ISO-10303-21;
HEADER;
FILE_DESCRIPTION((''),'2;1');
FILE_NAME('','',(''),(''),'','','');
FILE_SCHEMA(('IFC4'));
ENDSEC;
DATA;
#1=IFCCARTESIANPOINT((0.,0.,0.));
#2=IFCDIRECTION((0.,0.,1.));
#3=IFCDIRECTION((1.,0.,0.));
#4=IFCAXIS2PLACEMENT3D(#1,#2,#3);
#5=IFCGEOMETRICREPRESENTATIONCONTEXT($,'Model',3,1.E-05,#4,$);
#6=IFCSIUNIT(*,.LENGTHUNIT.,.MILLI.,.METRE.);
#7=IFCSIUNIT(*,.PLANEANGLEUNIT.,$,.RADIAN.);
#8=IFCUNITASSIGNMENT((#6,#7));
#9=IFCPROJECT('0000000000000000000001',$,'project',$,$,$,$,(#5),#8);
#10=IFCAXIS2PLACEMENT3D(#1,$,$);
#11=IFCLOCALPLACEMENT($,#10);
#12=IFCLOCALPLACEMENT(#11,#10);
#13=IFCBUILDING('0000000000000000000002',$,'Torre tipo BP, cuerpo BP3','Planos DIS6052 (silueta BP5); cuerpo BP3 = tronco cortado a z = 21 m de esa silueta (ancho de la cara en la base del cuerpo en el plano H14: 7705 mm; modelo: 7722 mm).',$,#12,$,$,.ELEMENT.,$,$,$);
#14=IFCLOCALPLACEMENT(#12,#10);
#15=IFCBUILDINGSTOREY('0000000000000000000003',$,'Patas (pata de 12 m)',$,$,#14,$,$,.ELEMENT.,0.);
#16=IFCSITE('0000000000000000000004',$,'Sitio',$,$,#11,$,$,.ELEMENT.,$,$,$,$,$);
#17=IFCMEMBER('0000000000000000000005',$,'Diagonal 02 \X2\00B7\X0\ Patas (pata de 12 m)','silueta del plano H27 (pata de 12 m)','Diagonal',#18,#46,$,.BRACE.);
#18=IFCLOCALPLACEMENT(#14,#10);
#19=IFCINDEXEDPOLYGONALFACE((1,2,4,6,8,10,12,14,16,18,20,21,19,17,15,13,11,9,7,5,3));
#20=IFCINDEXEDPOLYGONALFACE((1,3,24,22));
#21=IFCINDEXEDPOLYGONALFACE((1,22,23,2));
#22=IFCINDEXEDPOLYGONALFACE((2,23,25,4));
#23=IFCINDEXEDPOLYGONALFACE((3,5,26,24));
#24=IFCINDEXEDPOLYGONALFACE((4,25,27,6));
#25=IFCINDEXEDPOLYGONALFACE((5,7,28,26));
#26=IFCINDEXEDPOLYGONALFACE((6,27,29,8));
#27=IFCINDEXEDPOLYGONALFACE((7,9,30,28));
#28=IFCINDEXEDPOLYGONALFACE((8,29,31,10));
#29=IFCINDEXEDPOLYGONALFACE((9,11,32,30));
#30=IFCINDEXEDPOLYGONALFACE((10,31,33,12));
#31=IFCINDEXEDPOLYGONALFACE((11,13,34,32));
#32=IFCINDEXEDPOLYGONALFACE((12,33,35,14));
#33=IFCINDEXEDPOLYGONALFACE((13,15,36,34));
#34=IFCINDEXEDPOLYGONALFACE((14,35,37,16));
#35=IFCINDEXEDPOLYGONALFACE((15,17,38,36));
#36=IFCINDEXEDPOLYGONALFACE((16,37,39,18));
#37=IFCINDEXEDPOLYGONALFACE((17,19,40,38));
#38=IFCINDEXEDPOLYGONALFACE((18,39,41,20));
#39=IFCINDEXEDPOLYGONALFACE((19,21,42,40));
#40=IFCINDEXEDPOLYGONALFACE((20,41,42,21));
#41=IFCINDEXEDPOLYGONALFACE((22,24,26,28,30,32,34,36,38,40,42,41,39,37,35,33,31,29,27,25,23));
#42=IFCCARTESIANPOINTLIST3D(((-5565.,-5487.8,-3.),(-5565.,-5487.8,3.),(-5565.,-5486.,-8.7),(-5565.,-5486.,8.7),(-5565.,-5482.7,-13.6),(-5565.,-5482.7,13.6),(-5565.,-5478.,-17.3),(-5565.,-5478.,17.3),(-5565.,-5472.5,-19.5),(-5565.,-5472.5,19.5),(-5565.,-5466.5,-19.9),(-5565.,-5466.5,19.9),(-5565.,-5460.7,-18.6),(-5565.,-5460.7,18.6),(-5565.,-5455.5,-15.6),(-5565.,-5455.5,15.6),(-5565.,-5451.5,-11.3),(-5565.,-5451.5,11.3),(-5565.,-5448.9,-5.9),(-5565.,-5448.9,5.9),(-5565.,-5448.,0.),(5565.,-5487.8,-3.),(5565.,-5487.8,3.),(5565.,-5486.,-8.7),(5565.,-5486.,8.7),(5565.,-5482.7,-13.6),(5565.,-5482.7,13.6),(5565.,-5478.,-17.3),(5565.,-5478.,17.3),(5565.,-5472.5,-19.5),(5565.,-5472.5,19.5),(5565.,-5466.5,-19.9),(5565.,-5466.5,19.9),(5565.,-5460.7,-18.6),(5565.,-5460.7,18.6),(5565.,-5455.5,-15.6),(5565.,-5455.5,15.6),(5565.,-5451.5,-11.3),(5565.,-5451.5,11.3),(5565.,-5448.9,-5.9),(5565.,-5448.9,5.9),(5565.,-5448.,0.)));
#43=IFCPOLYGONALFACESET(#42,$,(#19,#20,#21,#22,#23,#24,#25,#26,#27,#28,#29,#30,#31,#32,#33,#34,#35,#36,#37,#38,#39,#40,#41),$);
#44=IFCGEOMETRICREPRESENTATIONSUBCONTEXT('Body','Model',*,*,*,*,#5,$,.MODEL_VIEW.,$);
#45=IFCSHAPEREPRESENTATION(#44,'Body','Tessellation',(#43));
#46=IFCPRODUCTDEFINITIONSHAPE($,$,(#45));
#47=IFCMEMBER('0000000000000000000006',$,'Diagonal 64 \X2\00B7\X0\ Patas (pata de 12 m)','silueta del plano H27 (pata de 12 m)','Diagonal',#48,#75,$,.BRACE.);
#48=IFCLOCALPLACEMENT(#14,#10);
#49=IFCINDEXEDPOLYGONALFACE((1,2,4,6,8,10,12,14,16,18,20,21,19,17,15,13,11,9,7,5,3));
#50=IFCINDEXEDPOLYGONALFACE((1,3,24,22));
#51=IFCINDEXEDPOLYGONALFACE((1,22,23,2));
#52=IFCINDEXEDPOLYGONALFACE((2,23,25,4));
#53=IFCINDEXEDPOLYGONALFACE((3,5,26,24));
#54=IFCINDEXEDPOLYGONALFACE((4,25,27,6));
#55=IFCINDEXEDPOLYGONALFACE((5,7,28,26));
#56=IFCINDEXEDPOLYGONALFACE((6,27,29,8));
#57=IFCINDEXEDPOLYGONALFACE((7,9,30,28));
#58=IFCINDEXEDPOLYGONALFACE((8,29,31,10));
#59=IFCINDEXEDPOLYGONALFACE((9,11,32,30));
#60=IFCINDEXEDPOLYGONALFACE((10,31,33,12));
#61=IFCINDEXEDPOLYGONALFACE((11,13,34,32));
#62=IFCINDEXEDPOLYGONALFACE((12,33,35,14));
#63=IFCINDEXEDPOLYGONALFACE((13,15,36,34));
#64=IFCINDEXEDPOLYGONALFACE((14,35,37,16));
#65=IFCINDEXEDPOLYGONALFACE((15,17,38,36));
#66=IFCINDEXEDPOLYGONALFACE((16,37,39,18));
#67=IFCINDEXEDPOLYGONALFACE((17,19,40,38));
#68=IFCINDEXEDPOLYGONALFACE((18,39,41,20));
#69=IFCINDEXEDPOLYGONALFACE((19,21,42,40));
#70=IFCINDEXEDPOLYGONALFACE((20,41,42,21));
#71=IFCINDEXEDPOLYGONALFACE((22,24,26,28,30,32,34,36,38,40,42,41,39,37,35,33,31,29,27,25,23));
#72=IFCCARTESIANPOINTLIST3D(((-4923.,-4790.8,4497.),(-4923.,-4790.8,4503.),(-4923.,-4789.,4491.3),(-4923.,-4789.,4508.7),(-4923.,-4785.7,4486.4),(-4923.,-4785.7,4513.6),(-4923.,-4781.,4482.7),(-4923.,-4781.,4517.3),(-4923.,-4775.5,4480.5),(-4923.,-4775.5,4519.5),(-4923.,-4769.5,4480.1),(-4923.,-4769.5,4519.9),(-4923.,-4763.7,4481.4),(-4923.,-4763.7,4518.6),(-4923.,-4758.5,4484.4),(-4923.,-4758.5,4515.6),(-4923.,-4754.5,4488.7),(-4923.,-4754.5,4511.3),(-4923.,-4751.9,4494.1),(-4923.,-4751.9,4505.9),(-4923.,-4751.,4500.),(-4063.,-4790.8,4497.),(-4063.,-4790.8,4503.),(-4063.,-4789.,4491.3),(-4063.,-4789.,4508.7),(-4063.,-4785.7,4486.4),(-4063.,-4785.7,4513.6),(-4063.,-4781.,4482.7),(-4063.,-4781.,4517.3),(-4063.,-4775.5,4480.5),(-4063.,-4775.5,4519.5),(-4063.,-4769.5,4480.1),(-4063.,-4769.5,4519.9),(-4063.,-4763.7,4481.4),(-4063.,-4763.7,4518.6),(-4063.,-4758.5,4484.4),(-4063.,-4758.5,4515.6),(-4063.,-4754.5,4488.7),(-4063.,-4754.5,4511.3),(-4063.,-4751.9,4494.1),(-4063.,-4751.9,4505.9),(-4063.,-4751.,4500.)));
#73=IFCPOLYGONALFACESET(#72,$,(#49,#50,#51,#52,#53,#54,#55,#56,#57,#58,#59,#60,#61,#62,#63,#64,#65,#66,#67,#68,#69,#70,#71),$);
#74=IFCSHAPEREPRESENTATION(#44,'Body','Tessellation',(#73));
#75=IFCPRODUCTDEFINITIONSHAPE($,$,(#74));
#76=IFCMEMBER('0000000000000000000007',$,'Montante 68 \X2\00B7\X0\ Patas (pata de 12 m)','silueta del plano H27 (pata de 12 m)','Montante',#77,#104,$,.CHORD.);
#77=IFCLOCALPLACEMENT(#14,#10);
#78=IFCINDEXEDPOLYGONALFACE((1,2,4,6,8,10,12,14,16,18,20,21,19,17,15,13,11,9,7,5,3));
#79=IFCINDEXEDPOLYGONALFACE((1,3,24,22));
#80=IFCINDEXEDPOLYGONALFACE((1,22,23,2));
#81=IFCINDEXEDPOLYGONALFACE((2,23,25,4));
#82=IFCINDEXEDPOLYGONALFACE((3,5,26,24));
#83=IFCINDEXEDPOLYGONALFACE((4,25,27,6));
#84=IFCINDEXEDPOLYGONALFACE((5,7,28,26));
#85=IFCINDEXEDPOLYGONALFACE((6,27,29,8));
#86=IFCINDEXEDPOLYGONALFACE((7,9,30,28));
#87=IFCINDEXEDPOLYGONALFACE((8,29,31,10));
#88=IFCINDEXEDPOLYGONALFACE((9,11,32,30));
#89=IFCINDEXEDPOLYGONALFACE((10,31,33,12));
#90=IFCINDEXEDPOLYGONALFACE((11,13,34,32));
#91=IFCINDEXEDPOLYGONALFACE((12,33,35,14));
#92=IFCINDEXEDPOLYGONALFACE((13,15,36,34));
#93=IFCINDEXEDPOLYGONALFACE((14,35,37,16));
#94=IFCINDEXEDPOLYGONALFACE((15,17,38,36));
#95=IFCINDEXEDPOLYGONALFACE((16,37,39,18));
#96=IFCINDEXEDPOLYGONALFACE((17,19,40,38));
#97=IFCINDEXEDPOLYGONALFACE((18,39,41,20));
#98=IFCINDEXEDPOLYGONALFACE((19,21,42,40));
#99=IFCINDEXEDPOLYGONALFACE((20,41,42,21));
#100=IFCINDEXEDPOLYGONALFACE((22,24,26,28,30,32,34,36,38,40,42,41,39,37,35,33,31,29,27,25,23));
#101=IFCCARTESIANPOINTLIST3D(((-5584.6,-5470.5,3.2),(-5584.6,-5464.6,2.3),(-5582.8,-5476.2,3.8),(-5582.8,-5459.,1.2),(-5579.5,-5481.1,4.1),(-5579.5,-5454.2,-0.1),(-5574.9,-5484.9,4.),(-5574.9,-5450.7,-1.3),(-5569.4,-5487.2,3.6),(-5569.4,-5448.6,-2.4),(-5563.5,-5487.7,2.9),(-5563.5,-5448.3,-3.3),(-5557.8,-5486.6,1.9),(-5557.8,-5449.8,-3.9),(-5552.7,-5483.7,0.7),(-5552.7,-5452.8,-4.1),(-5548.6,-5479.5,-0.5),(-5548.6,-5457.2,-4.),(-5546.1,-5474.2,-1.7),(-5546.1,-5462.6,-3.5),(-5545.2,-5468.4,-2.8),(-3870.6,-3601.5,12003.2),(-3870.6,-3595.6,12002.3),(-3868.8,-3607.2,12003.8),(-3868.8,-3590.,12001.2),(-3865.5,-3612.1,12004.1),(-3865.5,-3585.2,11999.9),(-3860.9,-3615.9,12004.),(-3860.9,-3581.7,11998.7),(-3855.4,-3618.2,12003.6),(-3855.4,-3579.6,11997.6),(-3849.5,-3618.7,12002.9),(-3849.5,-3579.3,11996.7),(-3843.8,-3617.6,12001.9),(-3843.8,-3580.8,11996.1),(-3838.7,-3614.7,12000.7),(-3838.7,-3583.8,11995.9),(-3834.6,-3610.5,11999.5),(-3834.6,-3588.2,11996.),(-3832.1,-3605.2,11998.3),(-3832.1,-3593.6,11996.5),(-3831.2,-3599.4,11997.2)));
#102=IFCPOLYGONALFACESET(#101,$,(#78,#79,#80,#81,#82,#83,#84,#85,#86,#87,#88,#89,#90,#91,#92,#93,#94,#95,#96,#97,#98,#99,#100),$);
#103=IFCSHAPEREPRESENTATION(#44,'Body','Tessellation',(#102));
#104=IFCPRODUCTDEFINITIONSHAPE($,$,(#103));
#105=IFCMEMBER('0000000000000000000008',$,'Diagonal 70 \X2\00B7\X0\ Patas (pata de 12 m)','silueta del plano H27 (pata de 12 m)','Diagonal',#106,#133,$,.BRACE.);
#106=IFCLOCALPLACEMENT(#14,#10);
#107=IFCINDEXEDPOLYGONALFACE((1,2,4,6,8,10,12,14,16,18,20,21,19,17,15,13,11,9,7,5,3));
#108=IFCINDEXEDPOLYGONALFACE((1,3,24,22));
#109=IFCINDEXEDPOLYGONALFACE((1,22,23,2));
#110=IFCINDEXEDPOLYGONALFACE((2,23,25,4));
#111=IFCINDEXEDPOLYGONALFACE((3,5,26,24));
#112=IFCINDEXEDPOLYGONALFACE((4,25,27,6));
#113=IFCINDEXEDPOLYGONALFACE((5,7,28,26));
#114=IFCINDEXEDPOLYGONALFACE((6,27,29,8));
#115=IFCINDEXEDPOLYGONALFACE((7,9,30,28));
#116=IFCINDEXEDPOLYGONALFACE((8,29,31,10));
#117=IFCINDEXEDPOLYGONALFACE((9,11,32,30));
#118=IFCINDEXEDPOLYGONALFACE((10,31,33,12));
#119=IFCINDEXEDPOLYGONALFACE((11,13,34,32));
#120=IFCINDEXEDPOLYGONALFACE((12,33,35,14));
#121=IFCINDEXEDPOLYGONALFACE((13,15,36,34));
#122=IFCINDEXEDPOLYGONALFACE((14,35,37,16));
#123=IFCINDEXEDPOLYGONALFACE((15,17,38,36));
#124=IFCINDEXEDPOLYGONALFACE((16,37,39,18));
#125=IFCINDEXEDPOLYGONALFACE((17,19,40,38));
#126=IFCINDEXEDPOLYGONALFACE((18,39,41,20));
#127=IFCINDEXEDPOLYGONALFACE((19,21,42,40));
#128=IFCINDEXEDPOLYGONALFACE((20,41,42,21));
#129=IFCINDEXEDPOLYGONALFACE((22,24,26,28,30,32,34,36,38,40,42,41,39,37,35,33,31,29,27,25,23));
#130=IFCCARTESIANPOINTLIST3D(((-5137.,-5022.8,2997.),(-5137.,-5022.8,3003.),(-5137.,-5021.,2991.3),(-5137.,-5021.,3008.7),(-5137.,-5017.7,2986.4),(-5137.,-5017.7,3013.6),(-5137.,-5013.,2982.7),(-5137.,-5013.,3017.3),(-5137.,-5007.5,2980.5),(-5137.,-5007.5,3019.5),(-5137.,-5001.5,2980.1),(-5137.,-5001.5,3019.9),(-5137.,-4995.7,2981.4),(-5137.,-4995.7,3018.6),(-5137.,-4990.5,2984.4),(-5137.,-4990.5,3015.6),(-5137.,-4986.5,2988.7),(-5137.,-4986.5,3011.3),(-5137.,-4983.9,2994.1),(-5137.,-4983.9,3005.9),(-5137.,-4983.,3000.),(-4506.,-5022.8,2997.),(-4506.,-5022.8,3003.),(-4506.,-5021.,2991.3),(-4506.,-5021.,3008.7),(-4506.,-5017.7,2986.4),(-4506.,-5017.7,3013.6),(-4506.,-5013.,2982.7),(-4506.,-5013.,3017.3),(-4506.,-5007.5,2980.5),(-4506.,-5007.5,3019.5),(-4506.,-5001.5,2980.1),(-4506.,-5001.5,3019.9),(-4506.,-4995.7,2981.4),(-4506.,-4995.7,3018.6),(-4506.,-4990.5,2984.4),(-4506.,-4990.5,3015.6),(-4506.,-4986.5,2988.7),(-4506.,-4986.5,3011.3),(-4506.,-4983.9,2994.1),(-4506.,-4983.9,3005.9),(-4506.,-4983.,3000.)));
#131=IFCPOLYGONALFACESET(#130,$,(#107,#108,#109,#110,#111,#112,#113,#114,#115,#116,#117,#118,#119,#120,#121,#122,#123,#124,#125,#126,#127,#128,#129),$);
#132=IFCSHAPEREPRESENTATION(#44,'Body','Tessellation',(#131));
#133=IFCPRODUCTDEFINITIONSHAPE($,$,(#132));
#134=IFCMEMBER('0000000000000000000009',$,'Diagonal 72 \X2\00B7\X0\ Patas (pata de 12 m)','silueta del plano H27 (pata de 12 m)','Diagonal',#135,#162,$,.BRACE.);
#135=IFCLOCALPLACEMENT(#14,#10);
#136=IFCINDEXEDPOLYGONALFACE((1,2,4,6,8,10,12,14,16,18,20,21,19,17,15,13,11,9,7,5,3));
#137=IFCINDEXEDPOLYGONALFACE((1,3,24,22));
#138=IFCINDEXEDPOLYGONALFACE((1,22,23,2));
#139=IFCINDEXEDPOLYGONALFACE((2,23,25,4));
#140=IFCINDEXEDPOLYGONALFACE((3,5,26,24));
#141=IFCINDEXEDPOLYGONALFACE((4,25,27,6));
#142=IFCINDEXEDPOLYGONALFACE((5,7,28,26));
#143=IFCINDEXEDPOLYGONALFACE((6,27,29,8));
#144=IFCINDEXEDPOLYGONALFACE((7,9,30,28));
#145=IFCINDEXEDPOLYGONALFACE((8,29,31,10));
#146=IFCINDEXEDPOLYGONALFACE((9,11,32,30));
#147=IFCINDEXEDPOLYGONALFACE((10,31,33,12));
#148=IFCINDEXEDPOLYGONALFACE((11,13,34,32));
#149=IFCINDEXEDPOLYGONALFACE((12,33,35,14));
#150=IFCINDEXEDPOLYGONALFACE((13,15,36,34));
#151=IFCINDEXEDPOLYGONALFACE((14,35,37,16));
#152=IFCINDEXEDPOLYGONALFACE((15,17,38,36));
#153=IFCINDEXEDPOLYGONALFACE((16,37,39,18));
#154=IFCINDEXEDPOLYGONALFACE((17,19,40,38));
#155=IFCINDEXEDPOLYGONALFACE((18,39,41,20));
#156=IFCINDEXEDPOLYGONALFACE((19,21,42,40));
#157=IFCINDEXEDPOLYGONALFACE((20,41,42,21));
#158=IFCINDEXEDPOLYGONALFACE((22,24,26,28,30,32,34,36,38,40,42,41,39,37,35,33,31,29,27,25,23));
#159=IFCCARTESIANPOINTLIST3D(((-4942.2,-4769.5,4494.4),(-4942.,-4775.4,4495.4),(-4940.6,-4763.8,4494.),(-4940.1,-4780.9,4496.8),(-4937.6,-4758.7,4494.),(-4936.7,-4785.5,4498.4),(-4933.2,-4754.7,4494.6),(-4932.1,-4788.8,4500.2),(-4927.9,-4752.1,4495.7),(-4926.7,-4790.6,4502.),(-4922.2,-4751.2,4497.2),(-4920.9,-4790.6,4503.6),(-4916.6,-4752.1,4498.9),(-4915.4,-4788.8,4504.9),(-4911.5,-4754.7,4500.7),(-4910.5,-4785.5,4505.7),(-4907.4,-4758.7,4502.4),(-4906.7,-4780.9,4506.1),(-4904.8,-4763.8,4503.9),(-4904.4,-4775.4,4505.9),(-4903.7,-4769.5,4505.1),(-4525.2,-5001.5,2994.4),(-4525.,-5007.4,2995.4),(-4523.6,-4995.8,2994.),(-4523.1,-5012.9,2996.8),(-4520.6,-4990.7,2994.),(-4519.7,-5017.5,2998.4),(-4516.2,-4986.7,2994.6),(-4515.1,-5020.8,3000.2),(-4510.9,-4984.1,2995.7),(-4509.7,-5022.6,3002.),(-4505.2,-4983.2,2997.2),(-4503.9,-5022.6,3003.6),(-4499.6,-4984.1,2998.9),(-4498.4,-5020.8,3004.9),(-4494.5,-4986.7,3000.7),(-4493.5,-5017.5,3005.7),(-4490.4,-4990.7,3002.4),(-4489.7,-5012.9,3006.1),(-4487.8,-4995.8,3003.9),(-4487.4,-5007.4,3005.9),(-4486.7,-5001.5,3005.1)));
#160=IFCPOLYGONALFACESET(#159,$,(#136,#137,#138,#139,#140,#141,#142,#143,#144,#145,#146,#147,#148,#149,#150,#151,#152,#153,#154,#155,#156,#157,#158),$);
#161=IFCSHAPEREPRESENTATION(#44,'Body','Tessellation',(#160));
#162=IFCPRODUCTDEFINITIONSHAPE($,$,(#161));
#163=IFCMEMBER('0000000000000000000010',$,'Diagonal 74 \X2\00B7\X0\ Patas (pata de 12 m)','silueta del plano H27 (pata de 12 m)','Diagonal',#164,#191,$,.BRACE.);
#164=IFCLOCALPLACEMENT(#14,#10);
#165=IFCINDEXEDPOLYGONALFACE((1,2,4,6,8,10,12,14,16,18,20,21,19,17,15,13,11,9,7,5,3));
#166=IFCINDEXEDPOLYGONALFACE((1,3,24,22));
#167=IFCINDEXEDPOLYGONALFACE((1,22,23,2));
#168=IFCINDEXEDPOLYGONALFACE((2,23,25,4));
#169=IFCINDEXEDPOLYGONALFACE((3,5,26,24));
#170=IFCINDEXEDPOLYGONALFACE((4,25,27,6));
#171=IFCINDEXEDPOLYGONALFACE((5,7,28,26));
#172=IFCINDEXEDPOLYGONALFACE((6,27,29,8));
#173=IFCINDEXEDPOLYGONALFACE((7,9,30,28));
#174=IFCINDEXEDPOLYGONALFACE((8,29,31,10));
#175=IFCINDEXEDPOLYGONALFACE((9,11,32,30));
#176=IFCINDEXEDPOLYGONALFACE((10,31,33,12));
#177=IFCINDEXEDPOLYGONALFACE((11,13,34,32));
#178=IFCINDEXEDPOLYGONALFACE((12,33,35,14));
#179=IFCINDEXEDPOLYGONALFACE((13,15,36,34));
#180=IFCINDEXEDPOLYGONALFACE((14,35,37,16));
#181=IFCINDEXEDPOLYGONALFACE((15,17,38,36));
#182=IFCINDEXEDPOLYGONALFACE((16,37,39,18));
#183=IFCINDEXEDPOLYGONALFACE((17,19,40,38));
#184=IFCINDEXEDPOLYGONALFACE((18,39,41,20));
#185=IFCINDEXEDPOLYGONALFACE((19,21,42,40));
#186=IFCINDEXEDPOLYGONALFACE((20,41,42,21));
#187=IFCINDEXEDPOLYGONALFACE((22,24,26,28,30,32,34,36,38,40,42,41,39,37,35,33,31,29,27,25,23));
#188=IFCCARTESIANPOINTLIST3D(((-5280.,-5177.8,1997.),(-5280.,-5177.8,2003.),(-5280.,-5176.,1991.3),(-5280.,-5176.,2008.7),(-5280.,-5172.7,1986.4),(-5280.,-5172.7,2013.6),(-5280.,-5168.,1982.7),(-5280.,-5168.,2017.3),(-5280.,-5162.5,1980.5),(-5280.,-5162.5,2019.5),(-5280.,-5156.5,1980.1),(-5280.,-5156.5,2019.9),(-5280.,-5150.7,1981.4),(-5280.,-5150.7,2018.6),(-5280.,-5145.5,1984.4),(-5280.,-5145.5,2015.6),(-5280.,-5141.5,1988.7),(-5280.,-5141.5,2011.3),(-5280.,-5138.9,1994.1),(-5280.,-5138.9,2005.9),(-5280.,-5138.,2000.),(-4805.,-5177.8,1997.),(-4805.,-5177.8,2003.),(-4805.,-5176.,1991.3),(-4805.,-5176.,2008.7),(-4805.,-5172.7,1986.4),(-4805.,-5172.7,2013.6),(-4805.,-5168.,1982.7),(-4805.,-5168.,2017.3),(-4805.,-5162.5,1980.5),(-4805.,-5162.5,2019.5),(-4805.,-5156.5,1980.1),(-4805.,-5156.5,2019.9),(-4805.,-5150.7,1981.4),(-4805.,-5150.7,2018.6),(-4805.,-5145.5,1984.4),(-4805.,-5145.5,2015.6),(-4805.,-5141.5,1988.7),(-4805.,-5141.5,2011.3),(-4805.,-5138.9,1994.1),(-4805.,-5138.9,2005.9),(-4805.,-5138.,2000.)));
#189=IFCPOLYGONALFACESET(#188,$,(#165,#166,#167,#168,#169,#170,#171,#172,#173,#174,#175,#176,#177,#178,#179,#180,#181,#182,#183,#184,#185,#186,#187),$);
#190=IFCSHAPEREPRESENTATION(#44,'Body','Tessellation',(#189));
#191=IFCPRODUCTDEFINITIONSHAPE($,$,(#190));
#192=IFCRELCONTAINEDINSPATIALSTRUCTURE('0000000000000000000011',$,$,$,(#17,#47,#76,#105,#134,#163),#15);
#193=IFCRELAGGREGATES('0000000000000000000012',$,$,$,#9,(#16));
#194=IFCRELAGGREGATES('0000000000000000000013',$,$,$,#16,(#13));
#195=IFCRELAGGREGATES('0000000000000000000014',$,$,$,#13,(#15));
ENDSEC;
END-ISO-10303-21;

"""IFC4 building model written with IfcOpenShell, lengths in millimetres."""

from ifc_helpers import new_model, si_unit, frame, origin, origin_with_axes, place, context, subcontext, project, spatial, circle, extrude, element, save


model = new_model("IFC4")

# Units and contexts
model_context = context("Model", 3, precision=1e-05, world=origin_with_axes())
body_context = subcontext(model_context, "Body", "Model", "MODEL_VIEW")
ifc_project = project(units=[si_unit("LENGTHUNIT", "METRE", prefix="MILLI"), si_unit("PLANEANGLEUNIT", "RADIAN")], contexts=[model_context])

# Site, building, storey
site_placement = place(None, origin())
site = spatial("IfcSite", under=ifc_project, at=site_placement, Name="Sitio", CompositionType="ELEMENT")
building_placement = place(site_placement, origin())
building = spatial("IfcBuilding", under=site, at=building_placement, Name="Torre tipo BP, cuerpo BP3", Description="Planos DIS6052 (silueta BP5); cuerpo BP3 = tronco cortado a z = 21 m de esa silueta (ancho de la cara en la base del cuerpo en el plano H14: 7705 mm; modelo: 7722 mm).", CompositionType="ELEMENT")
storey_placement = place(building_placement, origin())
storey = spatial("IfcBuildingStorey", under=building, at=storey_placement, Name="Patas (pata de 12 m)", CompositionType="ELEMENT", Elevation=0.0)

# Members
member_1_placement = place(storey_placement, frame((-5565.0, -5468.0, 0.0), z_axis=(1.0, 0.0, 0.0), x_axis=(0.0, 1.0, 0.0)))
element("IfcMember", 1, at=member_1_placement, inside=storey, Name="Diagonal 02 · Patas (pata de 12 m)", Description="silueta del plano H27 (pata de 12 m)", ObjectType="Diagonal", PredefinedType="BRACE", context=body_context, shape_type="SweptSolid", body=[
    extrude(circle(Radius=20.0), None, (0.0, 0.0, 1.0), 11130.0),
])
member_2_placement = place(storey_placement, frame((-4923.0, -4771.0, 4500.0), z_axis=(1.0, 0.0, 0.0), x_axis=(0.0, 1.0, 0.0)))
element("IfcMember", 2, at=member_2_placement, inside=storey, Name="Diagonal 64 · Patas (pata de 12 m)", Description="silueta del plano H27 (pata de 12 m)", ObjectType="Diagonal", PredefinedType="BRACE", context=body_context, shape_type="SweptSolid", body=[
    extrude(circle(Radius=20.0), None, (0.0, 0.0, 1.0), 860.0),
])
member_3_placement = place(storey_placement, frame((-5565.0, -5468.0, 0.0), z_axis=(0.139747, 0.152384, 0.978391), x_axis=(0.990187, -0.021506, -0.138082)))
element("IfcMember", 3, at=member_3_placement, inside=storey, Name="Montante 68 · Patas (pata de 12 m)", Description="silueta del plano H27 (pata de 12 m)", ObjectType="Montante", PredefinedType="CHORD", context=body_context, shape_type="SweptSolid", body=[
    extrude(circle(Radius=20.0), None, (0.0, 0.0, 1.0), 12265.0),
])
member_4_placement = place(storey_placement, frame((-5137.0, -5003.0, 3000.0), z_axis=(1.0, 0.0, 0.0), x_axis=(0.0, 1.0, 0.0)))
element("IfcMember", 4, at=member_4_placement, inside=storey, Name="Diagonal 70 · Patas (pata de 12 m)", Description="silueta del plano H27 (pata de 12 m)", ObjectType="Diagonal", PredefinedType="BRACE", context=body_context, shape_type="SweptSolid", body=[
    extrude(circle(Radius=20.0), None, (0.0, 0.0, 1.0), 631.0),
])
member_5_placement = place(storey_placement, frame((-4506.0, -5003.0, 3000.0), z_axis=(-0.264917, 0.147388, 0.95294), x_axis=(0.039477, 0.989079, -0.142003)))
element("IfcMember", 5, at=member_5_placement, inside=storey, Name="Diagonal 72 · Patas (pata de 12 m)", Description="silueta del plano H27 (pata de 12 m)", ObjectType="Diagonal", PredefinedType="BRACE", context=body_context, shape_type="SweptSolid", body=[
    extrude(circle(Radius=20.0), None, (0.0, 0.0, 1.0), 1574.1),
])
member_6_placement = place(storey_placement, frame((-5280.0, -5158.0, 2000.0), z_axis=(1.0, 0.0, 0.0), x_axis=(0.0, 1.0, 0.0)))
element("IfcMember", 6, at=member_6_placement, inside=storey, Name="Diagonal 74 · Patas (pata de 12 m)", Description="silueta del plano H27 (pata de 12 m)", ObjectType="Diagonal", PredefinedType="BRACE", context=body_context, shape_type="SweptSolid", body=[
    extrude(circle(Radius=20.0), None, (0.0, 0.0, 1.0), 475.0),
])

save(model, "model.ifc")
